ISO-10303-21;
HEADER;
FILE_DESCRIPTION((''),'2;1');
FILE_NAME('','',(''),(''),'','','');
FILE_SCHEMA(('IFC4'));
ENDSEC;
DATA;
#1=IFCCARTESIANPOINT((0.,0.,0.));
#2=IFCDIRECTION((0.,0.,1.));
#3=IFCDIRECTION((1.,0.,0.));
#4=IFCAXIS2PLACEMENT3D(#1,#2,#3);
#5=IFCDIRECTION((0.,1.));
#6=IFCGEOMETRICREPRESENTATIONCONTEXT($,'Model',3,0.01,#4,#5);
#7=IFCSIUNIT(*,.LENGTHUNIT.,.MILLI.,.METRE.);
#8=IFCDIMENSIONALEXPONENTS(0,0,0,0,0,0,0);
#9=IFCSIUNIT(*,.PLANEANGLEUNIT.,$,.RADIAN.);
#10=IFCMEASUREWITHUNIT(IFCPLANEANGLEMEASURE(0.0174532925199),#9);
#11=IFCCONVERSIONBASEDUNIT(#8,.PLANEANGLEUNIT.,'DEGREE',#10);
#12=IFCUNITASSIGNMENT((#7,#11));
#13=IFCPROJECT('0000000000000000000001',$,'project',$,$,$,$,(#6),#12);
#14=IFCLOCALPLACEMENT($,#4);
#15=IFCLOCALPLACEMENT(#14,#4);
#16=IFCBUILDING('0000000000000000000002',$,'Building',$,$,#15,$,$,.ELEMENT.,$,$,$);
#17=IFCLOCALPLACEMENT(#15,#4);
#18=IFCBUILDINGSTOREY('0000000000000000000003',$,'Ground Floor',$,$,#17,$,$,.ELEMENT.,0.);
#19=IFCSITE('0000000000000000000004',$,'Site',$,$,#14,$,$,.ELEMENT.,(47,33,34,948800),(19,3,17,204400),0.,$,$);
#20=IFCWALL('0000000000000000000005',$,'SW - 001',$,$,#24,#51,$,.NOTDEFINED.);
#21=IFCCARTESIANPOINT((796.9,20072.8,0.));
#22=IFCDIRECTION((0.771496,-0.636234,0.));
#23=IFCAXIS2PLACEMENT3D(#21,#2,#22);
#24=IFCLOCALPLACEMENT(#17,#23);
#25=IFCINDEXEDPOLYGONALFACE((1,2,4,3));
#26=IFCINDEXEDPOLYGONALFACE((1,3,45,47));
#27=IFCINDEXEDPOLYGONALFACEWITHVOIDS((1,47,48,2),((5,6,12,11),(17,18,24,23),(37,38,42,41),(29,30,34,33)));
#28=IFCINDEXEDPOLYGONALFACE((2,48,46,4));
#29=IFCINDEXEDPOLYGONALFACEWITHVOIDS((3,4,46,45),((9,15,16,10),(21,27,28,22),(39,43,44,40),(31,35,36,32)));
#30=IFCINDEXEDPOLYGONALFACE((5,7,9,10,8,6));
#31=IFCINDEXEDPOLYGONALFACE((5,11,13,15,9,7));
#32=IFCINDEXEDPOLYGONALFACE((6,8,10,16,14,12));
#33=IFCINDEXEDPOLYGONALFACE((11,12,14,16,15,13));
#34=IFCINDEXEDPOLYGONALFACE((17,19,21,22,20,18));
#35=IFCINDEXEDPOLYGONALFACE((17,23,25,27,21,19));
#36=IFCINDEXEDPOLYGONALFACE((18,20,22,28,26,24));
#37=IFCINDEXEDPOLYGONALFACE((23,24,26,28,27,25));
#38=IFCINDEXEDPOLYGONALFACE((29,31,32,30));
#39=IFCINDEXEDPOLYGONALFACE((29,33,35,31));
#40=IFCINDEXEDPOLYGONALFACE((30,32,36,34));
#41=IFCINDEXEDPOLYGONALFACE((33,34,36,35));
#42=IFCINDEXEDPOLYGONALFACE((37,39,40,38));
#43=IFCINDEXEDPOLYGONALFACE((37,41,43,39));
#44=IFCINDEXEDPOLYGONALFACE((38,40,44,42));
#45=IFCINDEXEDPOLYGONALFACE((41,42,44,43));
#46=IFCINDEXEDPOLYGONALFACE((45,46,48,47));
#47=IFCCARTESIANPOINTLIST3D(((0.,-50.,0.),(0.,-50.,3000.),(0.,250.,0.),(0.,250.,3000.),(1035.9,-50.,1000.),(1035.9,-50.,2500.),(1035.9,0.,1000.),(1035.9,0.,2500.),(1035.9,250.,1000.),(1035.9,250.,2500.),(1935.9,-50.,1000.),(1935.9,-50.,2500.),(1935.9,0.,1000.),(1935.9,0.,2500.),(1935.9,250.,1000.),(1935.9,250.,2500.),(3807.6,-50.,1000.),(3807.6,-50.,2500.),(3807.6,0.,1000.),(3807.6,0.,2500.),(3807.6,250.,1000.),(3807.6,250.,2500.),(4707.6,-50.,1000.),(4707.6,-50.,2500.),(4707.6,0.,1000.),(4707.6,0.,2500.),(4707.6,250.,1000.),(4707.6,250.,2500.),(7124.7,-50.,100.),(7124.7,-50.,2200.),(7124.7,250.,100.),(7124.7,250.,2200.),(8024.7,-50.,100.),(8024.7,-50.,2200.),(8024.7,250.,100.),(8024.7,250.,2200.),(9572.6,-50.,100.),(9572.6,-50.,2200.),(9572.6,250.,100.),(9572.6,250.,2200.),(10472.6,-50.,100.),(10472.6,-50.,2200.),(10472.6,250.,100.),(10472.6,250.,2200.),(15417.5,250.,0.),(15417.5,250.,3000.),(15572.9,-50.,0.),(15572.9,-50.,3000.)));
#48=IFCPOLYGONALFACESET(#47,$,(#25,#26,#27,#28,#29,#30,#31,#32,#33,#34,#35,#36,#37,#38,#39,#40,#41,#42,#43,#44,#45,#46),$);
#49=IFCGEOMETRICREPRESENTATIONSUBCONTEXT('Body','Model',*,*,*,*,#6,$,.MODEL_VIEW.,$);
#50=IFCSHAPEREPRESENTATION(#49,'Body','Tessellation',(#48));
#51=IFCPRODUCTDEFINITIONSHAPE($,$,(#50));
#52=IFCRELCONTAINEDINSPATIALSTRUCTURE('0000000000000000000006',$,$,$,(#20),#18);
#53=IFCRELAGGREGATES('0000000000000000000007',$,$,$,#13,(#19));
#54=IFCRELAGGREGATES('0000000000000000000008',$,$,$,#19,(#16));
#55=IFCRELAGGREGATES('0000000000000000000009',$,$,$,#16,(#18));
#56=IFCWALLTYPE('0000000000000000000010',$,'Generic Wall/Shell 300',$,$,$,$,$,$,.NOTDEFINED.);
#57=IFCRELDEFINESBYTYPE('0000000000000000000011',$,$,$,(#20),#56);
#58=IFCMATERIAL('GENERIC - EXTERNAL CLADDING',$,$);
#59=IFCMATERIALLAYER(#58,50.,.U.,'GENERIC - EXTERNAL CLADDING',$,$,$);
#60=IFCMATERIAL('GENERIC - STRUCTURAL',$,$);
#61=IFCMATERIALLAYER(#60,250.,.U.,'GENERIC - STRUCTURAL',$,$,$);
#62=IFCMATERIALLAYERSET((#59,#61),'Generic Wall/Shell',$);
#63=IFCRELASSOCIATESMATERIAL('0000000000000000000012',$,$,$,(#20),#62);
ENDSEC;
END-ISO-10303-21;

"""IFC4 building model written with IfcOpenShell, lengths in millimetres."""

from ifc_helpers import new_model, entity, si_unit, converted_unit, direction, frame, origin_with_axes, origin_2d_with_axis, place, context, subcontext, project, spatial, line, indexed_curve, rectangle, outline, extrude, material, layer, layer_set, layer_usage, type_object, element, save


model = new_model("IFC4")

# Units and contexts
model_context = context("Model", 3, precision=0.01, world=origin_with_axes(), true_north=direction((0.0, 1.0)))
body_context = subcontext(model_context, "Body", "Model", "MODEL_VIEW")
ifc_project = project(units=[si_unit("LENGTHUNIT", "METRE", prefix="MILLI"), converted_unit("PLANEANGLEUNIT", "DEGREE", entity("IfcPlaneAngleMeasure", 0.0174532925199), si_unit("PLANEANGLEUNIT", "RADIAN"), dimensions=[0, 0, 0, 0, 0, 0, 0])], contexts=[model_context])

# Site, building, storey
site_placement = place(None, origin_with_axes())
site = spatial("IfcSite", under=ifc_project, at=site_placement, Name="Site", CompositionType="ELEMENT", RefLatitude=(47, 33, 34, 948800), RefLongitude=(19, 3, 17, 204400), RefElevation=0.0)
building_placement = place(site_placement, origin_with_axes())
building = spatial("IfcBuilding", under=site, at=building_placement, Name="Building", CompositionType="ELEMENT")
storey_placement = place(building_placement, origin_with_axes())
storey = spatial("IfcBuildingStorey", under=building, at=storey_placement, Name="Ground Floor", CompositionType="ELEMENT", Elevation=0.0)

# Wall, openings
ifc_material_1 = material(Name="GENERIC - EXTERNAL CLADDING")
ifc_layer_1 = layer(ifc_material_1, 50.0, ventilated="UNKNOWN", Name="GENERIC - EXTERNAL CLADDING")
ifc_material_2 = material(Name="GENERIC - STRUCTURAL")
ifc_layer_2 = layer(ifc_material_2, 250.0, ventilated="UNKNOWN", Name="GENERIC - STRUCTURAL")
ifc_layer_set = layer_set([ifc_layer_1, ifc_layer_2], Name="Generic Wall/Shell")
ifc_layer_usage_1 = layer_usage(ifc_layer_set, "AXIS2", "POSITIVE", -50.0)
wall_type = type_object("IfcWallType", Name="Generic Wall/Shell 300", PredefinedType="NOTDEFINED")
wall_1_placement = place(storey_placement, frame((796.9, 20072.8, 0.0), z_axis=(0.0, 0.0, 1.0), x_axis=(0.771496, -0.636234, 0.0)))
wall_1 = element("IfcWall", 1, at=wall_1_placement, inside=storey, type_object=wall_type, material=ifc_layer_usage_1, Name="SW - 001", PredefinedType="NOTDEFINED", context=body_context, shape_type="SweptSolid", body=[
    extrude(outline(indexed_curve([(0.0, -50.0), (15572.9, -50.0), (15417.5, 250.0), (0.0, 250.0)], segments=[line(1, 2, 3, 4, 1)])), origin_with_axes(), (0.0, 0.0, 1.0), 3000.0),
])
opening_1_placement = place(wall_1_placement, frame((1485.9, 0.0, 1000.0), z_axis=(0.0, 0.0, 1.0), x_axis=(1.0, 0.0, 0.0)))
element("IfcOpeningElement", 2, at=opening_1_placement, cuts=wall_1, context=body_context, shape_type="SweptSolid", body=[
    extrude(rectangle(XDim=900.0, YDim=1500.0, at=origin_2d_with_axis()), frame((0.0, 0.0, 750.0), z_axis=(0.0, -1.0, 0.0), x_axis=(1.0, 0.0, 0.0)), (0.0, 0.0, -1.0), 550.0),
    extrude(rectangle(XDim=900.0, YDim=1500.0, at=origin_2d_with_axis()), frame((0.0, 0.0, 750.0), z_axis=(0.0, 1.0, 0.0), x_axis=(1.0, 0.0, 0.0)), (0.0, 0.0, -1.0), 350.0),
])
opening_2_placement = place(wall_1_placement, frame((4257.6, 0.0, 1000.0), z_axis=(0.0, 0.0, 1.0), x_axis=(1.0, 0.0, 0.0)))
element("IfcOpeningElement", 3, at=opening_2_placement, cuts=wall_1, context=body_context, shape_type="SweptSolid", body=[
    extrude(rectangle(XDim=900.0, YDim=1500.0, at=origin_2d_with_axis()), frame((0.0, 0.0, 750.0), z_axis=(0.0, -1.0, 0.0), x_axis=(1.0, 0.0, 0.0)), (0.0, 0.0, -1.0), 550.0),
    extrude(rectangle(XDim=900.0, YDim=1500.0, at=origin_2d_with_axis()), frame((0.0, 0.0, 750.0), z_axis=(0.0, 1.0, 0.0), x_axis=(1.0, 0.0, 0.0)), (0.0, 0.0, -1.0), 350.0),
])
opening_3_placement = place(wall_1_placement, frame((7574.7, 0.0, 100.0), z_axis=(0.0, 0.0, 1.0), x_axis=(1.0, 0.0, 0.0)))
element("IfcOpeningElement", 4, at=opening_3_placement, cuts=wall_1, context=body_context, shape_type="SweptSolid", body=[
    extrude(rectangle(XDim=900.0, YDim=2100.0, at=origin_2d_with_axis()), frame((0.0, 300.0, 1050.0), z_axis=(0.0, 1.0, 0.0), x_axis=(-1.0, 0.0, 0.0)), (0.0, 0.0, -1.0), 900.0),
    extrude(rectangle(XDim=974.0, YDim=2137.0, at=origin_2d_with_axis()), frame((0.0, 250.0, 1068.5), z_axis=(0.0, 1.0, 0.0), x_axis=(-1.0, 0.0, 0.0)), (0.0, 0.0, 1.0), 300.0),
    extrude(rectangle(XDim=974.0, YDim=2137.0, at=origin_2d_with_axis()), frame((0.0, -50.0, 1068.5), z_axis=(0.0, -1.0, 0.0), x_axis=(-1.0, 0.0, 0.0)), (0.0, 0.0, 1.0), 300.0),
])
opening_4_placement = place(wall_1_placement, frame((10022.6, 0.0, 100.0), z_axis=(0.0, 0.0, 1.0), x_axis=(1.0, 0.0, 0.0)))
element("IfcOpeningElement", 5, at=opening_4_placement, cuts=wall_1, context=body_context, shape_type="SweptSolid", body=[
    extrude(rectangle(XDim=900.0, YDim=2100.0, at=origin_2d_with_axis()), frame((0.0, 300.0, 1050.0), z_axis=(0.0, 1.0, 0.0), x_axis=(-1.0, 0.0, 0.0)), (0.0, 0.0, -1.0), 900.0),
    extrude(rectangle(XDim=974.0, YDim=2137.0, at=origin_2d_with_axis()), frame((0.0, 250.0, 1068.5), z_axis=(0.0, 1.0, 0.0), x_axis=(-1.0, 0.0, 0.0)), (0.0, 0.0, 1.0), 300.0),
    extrude(rectangle(XDim=974.0, YDim=2137.0, at=origin_2d_with_axis()), frame((0.0, -50.0, 1068.5), z_axis=(0.0, -1.0, 0.0), x_axis=(-1.0, 0.0, 0.0)), (0.0, 0.0, 1.0), 300.0),
])

save(model, "model.ifc")
